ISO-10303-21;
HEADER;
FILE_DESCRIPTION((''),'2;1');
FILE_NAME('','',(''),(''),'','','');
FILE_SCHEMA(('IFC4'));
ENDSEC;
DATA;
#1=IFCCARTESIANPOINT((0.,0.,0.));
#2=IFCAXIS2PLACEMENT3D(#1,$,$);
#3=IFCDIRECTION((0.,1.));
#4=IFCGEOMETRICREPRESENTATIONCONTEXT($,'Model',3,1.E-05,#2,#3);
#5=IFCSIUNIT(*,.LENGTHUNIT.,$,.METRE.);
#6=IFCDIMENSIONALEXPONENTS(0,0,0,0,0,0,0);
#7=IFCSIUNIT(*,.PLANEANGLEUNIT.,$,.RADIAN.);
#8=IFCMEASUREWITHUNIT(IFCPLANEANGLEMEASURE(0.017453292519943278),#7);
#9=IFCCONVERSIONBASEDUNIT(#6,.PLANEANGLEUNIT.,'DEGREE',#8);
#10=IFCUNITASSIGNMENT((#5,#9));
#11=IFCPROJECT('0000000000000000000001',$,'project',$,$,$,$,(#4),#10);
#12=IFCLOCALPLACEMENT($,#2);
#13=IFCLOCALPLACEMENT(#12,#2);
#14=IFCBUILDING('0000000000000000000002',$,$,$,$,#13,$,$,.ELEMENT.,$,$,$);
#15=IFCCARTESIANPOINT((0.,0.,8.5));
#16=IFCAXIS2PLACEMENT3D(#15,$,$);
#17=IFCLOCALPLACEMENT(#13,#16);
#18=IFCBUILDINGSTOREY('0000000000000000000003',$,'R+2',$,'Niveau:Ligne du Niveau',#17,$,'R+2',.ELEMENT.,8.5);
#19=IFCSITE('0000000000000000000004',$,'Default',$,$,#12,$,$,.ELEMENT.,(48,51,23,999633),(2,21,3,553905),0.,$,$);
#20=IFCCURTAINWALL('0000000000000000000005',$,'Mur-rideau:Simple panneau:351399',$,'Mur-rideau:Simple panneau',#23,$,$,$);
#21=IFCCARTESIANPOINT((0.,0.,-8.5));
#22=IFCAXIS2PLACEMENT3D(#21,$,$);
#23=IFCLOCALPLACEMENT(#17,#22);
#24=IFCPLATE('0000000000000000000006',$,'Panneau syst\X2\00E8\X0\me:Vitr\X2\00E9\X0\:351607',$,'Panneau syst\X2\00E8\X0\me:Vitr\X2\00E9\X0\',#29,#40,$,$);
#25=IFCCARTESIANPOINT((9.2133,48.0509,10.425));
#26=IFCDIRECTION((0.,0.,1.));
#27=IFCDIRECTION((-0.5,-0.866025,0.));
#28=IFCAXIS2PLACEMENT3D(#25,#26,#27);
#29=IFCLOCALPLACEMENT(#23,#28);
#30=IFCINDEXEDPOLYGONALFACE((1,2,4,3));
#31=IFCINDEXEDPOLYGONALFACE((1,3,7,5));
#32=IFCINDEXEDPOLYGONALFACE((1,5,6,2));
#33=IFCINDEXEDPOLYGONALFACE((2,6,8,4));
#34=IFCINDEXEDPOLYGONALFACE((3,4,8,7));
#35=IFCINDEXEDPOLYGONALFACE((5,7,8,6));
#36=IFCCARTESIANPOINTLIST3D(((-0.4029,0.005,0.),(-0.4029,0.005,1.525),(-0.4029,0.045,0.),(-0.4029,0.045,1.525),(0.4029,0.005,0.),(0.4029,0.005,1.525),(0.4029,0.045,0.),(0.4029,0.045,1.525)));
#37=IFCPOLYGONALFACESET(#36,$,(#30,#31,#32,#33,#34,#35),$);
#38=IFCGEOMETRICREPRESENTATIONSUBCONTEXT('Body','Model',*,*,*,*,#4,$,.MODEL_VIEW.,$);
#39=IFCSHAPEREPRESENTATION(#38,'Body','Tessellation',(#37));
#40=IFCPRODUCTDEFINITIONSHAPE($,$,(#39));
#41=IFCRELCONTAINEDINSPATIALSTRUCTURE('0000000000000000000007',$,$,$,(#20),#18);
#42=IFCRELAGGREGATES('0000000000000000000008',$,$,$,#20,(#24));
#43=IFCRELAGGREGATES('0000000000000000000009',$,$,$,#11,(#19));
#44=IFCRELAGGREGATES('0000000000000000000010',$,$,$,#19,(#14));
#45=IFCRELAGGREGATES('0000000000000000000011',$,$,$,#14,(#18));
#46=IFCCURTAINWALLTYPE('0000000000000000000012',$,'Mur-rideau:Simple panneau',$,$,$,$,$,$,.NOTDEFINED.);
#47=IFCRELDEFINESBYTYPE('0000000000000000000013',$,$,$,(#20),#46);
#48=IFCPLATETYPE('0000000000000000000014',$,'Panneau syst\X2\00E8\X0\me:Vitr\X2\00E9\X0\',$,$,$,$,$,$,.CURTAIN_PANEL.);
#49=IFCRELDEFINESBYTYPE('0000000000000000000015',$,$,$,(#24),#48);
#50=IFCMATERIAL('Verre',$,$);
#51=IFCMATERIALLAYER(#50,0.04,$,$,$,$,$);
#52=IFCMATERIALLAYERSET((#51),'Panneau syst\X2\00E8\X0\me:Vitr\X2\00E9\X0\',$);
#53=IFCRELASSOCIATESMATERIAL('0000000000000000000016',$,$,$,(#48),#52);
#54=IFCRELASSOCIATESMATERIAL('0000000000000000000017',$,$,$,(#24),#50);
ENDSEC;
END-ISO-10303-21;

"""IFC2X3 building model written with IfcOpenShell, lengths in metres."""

from ifc_helpers import new_model, entity, si_unit, converted_unit, direction, frame, frame_2d, origin, place, context, subcontext, project, spatial, rectangle, extrude, source, transform, mapped, material, layer, layer_set, type_object, type_shapes, element, aggregate, save


model = new_model("IFC2X3")

# Units and contexts
model_context = context("Model", 3, precision=1e-05, world=origin(), true_north=direction((0.0, 1.0)))
body_context = subcontext(model_context, "Body", "Model", "MODEL_VIEW")
ifc_project = project(units=[si_unit("LENGTHUNIT", "METRE"), converted_unit("PLANEANGLEUNIT", "DEGREE", entity("IfcPlaneAngleMeasure", 0.017453292519943278), si_unit("PLANEANGLEUNIT", "RADIAN"), dimensions=[0, 0, 0, 0, 0, 0, 0])], contexts=[model_context])

# Site, building, storey
site_placement = place(None, origin())
site = spatial("IfcSite", under=ifc_project, at=site_placement, Name="Default", CompositionType="ELEMENT", RefLatitude=(48, 51, 23, 999633), RefLongitude=(2, 21, 3, 553905), RefElevation=0.0)
building_placement = place(site_placement, origin())
building = spatial("IfcBuilding", under=site, at=building_placement, CompositionType="ELEMENT")
storey_placement = place(building_placement, frame((0.0, 0.0, 8.5)))
storey = spatial("IfcBuildingStorey", under=building, at=storey_placement, Name="R+2", ObjectType="Niveau:Ligne du Niveau", LongName="R+2", CompositionType="ELEMENT", Elevation=8.5)

# Curtain wall, plate
curtain_wall_type = type_object("IfcCurtainWallType", Name="Mur-rideau:Simple panneau", PredefinedType="NOTDEFINED")
curtain_wall_placement = place(storey_placement, frame((0.0, 0.0, -8.5)))
curtain_wall = element("IfcCurtainWall", 1, at=curtain_wall_placement, inside=storey, type_object=curtain_wall_type, Name="Mur-rideau:Simple panneau:351399", ObjectType="Mur-rideau:Simple panneau")
ifc_material_1 = material(Name="Verre")
ifc_layer_1 = layer(ifc_material_1, 0.04)
ifc_layer_set_1 = layer_set([ifc_layer_1], Name="Panneau système:Vitré")
plate_type_1 = type_object("IfcPlateType", Name="Panneau système:Vitré", PredefinedType="CURTAIN_PANEL", material=ifc_layer_set_1)
shared_shape_1 = source(origin(), body_context, "Body", "SweptSolid", [
    extrude(rectangle(XDim=0.04, YDim=0.8058, at=frame_2d((0.0, 0.0), x_axis=(1.0, 0.0))), frame((0.0, 0.025, 0.0), z_axis=(0.0, 0.0, 1.0), x_axis=(0.0, 1.0, 0.0)), (0.0, 0.0, 1.0), 1.525),
])
type_shapes(plate_type_1, [shared_shape_1])
plate_1_placement = place(curtain_wall_placement, frame((9.2133, 48.0509, 10.425), z_axis=(0.0, 0.0, 1.0), x_axis=(-0.5, -0.866025, 0.0)))
plate_1 = element("IfcPlate", 2, at=plate_1_placement, type_object=plate_type_1, material=ifc_material_1, Name="Panneau système:Vitré:351607", ObjectType="Panneau système:Vitré", context=body_context, shape_type="MappedRepresentation", body=[
    mapped(shared_shape_1, transform((0.0, 0.0, 0.0), scale=1.0)),
])
aggregate(curtain_wall, [plate_1])

save(model, "model.ifc")
